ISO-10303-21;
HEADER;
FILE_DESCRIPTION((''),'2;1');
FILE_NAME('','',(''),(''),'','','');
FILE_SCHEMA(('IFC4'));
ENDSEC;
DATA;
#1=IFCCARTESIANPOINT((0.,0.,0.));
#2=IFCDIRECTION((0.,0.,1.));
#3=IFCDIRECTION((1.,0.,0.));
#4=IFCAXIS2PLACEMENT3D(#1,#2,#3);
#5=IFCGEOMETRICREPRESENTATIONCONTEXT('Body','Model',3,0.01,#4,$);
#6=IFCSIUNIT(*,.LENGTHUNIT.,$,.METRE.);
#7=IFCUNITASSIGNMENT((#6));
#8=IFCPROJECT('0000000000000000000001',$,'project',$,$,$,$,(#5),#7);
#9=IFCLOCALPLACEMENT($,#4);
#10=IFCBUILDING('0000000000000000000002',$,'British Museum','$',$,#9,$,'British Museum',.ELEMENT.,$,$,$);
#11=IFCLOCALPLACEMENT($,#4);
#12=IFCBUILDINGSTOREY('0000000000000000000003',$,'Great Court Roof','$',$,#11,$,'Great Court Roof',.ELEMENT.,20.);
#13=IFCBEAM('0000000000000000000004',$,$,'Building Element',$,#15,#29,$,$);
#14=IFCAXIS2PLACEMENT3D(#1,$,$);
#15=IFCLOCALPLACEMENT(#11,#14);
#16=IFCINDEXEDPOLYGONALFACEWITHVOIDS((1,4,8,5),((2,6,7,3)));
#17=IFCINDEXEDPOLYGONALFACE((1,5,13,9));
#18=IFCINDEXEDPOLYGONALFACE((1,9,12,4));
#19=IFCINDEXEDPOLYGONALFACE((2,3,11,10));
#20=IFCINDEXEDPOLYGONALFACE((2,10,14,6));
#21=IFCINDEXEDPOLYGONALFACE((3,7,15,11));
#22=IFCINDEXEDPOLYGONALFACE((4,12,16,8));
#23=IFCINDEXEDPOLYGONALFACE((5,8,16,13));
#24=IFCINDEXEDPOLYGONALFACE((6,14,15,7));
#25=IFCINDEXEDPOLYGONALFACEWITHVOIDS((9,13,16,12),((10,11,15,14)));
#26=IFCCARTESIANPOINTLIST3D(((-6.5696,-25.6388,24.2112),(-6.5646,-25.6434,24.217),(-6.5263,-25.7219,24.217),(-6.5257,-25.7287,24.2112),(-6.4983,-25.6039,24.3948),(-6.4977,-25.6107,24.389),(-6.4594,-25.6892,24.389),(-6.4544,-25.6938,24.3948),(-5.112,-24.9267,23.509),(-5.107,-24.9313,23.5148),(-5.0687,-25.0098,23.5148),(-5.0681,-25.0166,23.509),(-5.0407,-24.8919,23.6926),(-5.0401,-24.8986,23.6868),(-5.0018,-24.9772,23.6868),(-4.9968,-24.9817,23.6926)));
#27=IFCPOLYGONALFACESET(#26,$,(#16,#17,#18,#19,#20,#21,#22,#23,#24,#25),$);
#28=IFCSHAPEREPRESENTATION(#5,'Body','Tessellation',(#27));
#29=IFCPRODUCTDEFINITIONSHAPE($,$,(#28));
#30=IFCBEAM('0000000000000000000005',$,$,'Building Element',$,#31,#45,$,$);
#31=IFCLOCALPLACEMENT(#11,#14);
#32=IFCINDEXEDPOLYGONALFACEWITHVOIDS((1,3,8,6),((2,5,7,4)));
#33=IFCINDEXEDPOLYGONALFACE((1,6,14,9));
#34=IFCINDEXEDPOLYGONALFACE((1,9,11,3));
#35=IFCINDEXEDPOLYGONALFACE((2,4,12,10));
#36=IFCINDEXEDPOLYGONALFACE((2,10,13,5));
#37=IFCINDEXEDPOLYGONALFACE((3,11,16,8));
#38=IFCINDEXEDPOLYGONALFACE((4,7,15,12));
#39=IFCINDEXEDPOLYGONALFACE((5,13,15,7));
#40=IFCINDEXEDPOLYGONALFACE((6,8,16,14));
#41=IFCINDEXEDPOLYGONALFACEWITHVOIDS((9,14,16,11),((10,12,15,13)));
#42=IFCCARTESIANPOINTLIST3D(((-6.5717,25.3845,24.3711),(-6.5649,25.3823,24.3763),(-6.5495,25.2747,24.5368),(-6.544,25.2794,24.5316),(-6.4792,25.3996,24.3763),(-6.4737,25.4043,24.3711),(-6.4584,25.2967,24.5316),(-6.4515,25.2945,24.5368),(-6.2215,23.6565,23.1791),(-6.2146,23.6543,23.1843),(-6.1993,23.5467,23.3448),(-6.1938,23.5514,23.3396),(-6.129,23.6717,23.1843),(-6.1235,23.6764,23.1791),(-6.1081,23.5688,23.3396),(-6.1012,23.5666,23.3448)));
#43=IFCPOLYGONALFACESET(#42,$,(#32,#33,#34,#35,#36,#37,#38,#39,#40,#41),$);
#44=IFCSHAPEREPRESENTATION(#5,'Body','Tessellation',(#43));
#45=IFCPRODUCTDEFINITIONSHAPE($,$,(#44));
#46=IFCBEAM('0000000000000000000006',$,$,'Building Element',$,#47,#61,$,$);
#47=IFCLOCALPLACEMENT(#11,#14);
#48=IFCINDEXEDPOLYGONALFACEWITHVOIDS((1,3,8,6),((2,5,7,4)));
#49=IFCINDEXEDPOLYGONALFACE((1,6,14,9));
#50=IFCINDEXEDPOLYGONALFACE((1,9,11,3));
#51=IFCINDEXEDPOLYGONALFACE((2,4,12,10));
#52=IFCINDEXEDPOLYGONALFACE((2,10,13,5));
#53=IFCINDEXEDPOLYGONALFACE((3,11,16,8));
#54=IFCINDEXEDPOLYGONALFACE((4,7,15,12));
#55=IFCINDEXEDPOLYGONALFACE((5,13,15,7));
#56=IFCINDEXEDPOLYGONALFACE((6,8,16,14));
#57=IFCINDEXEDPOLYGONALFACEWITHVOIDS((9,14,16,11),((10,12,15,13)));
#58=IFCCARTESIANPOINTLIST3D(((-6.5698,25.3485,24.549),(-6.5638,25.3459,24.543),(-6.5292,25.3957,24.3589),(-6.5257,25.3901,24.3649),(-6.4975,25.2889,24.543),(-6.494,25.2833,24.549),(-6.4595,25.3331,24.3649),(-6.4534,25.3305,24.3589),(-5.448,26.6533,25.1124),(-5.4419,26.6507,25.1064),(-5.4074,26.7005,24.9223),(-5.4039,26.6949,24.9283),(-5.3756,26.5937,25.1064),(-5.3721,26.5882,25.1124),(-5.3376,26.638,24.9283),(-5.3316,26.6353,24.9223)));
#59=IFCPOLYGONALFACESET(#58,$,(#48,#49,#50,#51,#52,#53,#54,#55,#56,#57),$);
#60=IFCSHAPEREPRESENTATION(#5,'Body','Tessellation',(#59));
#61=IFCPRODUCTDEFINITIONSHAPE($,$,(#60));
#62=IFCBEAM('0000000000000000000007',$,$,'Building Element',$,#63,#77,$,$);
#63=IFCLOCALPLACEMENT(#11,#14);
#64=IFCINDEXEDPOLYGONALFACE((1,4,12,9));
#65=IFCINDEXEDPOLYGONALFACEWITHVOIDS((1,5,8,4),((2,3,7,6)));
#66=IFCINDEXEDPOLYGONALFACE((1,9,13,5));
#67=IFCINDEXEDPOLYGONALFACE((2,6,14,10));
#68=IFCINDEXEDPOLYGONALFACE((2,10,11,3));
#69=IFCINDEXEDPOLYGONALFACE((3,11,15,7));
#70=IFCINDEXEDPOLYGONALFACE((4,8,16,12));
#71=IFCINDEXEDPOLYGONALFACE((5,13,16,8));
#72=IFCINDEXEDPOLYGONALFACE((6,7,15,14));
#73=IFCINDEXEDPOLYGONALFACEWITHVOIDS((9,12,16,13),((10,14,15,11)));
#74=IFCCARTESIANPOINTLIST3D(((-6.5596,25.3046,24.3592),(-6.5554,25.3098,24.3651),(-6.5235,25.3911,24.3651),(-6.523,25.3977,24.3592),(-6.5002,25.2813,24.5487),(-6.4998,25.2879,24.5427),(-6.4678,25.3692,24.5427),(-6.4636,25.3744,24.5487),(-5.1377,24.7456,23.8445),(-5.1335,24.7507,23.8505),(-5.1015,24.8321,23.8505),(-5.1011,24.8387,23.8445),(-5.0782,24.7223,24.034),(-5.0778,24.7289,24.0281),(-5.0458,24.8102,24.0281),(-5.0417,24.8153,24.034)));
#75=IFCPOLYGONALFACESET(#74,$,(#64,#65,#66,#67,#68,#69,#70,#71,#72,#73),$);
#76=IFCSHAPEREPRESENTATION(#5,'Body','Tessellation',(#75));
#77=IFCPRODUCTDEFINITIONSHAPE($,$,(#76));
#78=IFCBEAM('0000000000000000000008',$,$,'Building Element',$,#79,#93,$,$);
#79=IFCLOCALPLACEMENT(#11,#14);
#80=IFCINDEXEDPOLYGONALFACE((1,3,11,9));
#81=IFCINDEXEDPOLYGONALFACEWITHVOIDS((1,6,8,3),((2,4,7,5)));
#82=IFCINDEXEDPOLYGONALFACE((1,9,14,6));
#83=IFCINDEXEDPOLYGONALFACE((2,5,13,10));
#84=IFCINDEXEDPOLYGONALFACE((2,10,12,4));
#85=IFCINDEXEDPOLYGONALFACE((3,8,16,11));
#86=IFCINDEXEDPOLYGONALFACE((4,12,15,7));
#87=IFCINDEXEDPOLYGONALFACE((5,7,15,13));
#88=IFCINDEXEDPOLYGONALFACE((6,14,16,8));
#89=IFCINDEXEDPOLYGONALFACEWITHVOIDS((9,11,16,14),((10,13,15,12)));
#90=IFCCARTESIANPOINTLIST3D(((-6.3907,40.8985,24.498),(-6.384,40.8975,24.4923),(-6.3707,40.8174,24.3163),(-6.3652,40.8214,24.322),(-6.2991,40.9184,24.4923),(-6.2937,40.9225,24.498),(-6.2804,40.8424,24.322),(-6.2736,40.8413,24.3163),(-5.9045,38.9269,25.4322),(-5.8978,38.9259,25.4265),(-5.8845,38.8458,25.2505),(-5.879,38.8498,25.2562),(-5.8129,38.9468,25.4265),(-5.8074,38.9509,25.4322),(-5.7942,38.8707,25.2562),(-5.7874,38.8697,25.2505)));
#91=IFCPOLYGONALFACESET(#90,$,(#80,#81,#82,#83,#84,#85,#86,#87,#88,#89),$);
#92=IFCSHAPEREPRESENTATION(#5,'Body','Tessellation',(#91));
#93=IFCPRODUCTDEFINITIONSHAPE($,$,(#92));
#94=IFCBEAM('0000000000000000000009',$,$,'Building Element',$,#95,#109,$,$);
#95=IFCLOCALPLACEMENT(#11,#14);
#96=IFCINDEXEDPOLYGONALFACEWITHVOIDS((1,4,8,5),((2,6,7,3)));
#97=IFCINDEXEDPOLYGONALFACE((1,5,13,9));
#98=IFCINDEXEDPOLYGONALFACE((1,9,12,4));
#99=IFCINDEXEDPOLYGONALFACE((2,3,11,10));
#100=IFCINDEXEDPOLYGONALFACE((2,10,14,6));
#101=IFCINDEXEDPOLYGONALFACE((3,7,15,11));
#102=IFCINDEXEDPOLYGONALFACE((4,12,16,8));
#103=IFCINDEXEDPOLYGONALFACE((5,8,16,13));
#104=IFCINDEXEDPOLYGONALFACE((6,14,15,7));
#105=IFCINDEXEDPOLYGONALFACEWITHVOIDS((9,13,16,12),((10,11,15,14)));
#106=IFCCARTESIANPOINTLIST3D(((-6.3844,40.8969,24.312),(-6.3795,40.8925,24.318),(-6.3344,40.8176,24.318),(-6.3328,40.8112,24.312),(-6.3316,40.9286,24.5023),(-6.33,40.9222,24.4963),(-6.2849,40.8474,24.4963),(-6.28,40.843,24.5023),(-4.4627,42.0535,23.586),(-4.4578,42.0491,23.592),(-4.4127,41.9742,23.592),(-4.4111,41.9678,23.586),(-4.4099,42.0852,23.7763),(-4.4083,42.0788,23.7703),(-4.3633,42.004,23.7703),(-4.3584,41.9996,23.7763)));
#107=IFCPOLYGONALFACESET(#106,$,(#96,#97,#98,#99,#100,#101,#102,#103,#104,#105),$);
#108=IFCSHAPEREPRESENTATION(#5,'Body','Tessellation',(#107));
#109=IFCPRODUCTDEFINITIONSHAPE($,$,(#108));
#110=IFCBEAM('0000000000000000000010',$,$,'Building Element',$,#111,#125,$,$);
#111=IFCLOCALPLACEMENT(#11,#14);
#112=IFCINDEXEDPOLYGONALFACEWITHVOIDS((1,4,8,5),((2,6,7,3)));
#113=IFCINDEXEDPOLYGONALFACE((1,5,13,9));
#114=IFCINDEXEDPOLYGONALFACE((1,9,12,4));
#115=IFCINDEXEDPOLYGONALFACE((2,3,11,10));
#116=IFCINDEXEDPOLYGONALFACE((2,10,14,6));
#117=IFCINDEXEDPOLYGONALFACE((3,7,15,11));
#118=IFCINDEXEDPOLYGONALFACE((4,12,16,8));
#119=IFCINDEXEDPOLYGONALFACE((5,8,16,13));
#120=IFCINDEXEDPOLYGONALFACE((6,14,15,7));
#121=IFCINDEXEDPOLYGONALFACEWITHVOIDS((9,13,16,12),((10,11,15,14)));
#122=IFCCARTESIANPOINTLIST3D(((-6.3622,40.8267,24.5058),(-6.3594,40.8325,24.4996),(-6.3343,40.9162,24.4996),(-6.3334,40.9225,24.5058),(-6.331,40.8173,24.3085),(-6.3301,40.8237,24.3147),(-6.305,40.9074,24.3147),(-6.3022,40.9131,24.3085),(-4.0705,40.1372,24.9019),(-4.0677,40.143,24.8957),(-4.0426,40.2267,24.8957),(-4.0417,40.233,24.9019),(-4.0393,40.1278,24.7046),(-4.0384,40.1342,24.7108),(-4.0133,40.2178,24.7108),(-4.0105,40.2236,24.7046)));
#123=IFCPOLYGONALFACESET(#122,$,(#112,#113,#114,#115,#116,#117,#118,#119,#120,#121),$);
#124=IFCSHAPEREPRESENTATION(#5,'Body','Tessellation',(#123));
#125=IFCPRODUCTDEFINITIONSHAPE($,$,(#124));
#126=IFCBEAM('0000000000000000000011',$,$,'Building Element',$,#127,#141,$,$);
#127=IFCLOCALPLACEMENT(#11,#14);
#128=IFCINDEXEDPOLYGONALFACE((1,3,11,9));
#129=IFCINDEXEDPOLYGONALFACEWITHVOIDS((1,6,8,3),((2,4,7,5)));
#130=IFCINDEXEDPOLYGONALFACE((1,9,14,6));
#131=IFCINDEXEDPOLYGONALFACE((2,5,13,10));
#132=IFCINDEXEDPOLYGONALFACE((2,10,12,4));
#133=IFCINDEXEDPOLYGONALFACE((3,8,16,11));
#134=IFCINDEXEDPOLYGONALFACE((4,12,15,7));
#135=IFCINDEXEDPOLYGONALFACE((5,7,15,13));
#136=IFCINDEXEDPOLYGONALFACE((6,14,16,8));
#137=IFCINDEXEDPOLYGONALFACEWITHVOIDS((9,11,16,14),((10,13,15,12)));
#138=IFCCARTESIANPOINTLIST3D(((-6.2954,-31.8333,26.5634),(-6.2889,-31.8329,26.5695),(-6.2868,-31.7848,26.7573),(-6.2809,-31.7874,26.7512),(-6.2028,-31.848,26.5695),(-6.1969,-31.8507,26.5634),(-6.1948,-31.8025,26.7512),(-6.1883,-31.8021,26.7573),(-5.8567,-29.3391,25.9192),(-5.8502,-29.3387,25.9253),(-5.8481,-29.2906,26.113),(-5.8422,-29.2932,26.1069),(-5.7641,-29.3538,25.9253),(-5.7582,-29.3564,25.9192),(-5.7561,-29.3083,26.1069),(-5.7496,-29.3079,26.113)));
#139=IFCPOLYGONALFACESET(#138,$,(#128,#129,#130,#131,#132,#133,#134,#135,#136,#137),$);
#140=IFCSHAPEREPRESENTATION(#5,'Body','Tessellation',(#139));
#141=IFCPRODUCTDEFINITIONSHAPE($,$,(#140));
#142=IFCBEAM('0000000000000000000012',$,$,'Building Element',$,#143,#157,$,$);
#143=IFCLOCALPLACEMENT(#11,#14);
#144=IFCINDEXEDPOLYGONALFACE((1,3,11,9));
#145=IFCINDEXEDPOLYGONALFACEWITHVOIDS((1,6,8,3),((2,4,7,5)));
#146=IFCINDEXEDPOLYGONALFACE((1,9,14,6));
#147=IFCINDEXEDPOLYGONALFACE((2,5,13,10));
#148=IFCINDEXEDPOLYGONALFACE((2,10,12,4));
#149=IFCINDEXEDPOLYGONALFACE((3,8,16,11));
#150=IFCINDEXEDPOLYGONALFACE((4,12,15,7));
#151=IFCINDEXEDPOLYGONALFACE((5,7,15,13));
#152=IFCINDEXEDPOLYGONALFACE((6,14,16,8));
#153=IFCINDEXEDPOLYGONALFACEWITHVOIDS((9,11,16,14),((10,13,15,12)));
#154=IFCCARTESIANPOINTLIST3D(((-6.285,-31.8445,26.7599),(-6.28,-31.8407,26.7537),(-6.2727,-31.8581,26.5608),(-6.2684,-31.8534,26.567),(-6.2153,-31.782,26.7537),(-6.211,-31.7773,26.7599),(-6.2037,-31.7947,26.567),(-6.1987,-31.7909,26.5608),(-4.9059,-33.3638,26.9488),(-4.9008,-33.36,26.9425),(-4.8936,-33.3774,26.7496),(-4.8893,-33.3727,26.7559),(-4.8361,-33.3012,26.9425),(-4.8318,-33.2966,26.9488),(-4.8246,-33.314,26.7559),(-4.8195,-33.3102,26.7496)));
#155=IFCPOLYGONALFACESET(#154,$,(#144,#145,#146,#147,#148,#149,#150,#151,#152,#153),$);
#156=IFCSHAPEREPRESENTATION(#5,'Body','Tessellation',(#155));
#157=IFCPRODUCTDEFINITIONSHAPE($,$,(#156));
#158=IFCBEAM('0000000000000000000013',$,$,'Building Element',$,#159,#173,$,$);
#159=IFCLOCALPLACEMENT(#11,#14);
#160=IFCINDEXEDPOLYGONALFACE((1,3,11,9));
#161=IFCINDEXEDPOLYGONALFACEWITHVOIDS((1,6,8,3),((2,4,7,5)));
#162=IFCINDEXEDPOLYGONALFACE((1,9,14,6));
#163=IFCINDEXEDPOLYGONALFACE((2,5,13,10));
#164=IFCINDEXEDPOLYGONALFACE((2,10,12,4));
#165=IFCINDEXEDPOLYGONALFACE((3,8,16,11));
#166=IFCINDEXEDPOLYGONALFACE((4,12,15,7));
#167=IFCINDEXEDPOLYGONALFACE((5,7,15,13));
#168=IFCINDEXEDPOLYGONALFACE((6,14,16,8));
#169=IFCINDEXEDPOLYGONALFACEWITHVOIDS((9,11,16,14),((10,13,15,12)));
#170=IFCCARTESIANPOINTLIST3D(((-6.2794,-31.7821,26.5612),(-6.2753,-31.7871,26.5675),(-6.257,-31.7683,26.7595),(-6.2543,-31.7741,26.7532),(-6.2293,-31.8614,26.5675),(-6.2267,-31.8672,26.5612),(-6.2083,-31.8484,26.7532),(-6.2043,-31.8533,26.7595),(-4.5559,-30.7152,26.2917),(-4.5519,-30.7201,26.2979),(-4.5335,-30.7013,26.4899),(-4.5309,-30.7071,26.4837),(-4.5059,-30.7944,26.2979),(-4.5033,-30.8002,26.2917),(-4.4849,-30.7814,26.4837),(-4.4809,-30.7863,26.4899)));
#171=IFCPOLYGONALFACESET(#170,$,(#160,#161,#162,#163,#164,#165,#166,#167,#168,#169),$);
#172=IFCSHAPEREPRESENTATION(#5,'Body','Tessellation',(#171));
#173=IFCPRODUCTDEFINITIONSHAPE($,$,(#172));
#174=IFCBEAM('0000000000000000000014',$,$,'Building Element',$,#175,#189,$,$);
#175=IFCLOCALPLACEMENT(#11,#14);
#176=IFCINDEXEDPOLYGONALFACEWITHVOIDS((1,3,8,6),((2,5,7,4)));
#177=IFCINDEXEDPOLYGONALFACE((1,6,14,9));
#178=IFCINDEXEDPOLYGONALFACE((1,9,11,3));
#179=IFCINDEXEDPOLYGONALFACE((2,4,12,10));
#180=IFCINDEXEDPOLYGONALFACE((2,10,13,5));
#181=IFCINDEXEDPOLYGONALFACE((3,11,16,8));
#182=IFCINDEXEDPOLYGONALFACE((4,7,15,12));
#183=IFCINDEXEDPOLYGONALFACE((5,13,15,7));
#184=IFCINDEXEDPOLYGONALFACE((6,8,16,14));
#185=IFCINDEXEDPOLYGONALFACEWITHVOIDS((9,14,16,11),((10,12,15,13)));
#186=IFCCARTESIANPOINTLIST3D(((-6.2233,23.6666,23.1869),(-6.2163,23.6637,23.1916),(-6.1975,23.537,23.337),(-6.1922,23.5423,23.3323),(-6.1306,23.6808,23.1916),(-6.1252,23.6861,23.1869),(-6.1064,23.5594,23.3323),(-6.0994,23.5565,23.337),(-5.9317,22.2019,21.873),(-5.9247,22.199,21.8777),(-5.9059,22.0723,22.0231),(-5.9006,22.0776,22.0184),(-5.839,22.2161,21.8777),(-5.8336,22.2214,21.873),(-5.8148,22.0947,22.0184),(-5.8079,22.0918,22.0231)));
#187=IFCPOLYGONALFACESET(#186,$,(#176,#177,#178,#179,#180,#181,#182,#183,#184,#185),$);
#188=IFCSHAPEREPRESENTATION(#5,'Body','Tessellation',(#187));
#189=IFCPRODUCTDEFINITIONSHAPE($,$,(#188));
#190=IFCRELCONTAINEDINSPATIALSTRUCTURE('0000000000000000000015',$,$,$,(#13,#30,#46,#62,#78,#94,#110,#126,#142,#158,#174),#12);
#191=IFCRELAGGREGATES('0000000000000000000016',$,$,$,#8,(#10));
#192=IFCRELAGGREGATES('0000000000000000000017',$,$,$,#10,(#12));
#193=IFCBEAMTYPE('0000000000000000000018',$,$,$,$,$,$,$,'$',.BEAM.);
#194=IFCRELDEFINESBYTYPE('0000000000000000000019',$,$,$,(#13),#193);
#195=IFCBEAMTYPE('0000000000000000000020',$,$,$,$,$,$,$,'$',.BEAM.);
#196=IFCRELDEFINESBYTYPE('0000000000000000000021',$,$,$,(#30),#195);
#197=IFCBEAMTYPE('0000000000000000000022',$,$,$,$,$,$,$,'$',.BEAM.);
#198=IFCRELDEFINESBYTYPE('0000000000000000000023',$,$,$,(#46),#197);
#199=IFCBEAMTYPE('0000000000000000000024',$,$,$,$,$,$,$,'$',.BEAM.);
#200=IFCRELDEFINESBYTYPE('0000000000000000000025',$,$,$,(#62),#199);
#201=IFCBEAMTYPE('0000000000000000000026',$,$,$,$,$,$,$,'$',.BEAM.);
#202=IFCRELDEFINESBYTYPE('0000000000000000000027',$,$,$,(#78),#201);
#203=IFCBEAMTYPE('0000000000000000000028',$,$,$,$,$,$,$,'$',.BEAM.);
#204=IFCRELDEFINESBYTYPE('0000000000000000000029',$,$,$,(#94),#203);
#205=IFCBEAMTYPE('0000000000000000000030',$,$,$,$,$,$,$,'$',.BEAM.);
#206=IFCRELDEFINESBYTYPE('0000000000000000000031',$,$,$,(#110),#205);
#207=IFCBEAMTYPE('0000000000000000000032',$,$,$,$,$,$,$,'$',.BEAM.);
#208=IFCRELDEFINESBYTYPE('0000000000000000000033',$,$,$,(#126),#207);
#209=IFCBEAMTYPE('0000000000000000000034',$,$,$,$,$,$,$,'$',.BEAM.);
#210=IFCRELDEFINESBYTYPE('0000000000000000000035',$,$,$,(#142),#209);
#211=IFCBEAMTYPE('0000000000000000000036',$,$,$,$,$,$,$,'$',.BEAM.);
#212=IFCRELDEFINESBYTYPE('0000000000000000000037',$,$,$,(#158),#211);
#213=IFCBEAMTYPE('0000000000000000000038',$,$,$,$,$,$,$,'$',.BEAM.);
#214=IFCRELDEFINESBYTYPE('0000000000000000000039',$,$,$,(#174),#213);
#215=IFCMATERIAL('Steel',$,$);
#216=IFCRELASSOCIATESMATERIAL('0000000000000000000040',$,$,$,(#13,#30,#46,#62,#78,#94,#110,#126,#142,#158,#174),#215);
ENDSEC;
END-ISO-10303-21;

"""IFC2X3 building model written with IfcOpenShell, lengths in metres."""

from ifc_helpers import new_model, si_unit, frame, origin_with_axes, origin_2d, place, context, project, spatial, hollow_rectangle, extrude, material, type_object, element, save


model = new_model("IFC2X3")

# Units and contexts
model_context = context("Model", 3, precision=0.01, world=origin_with_axes(), identifier="Body")
ifc_project = project(units=[si_unit("LENGTHUNIT", "METRE")], contexts=[model_context])

# Building, storey
building_placement = place(None, origin_with_axes())
building = spatial("IfcBuilding", under=ifc_project, at=building_placement, Name="British Museum", Description="$", LongName="British Museum", CompositionType="ELEMENT")
storey_placement = place(None, origin_with_axes())
storey = spatial("IfcBuildingStorey", under=building, at=storey_placement, Name="Great Court Roof", Description="$", LongName="Great Court Roof", CompositionType="ELEMENT", Elevation=20.0)

# Beams
ifc_material = material(Name="Steel")
beam_type_1 = type_object("IfcBeamType", ElementType="$", PredefinedType="BEAM")
beam_1_placement = place(None, origin_with_axes())
element("IfcBeam", 1, at=beam_1_placement, inside=storey, type_object=beam_type_1, material=ifc_material, Description="Building Element", context=model_context, shape_type="SweptSolid", body=[
    extrude(hollow_rectangle(XDim=0.1, YDim=0.2, WallThickness=0.0063, InnerFilletRadius=-0.0063, OuterFilletRadius=0.0, at=origin_2d()), frame((-6.512, -25.6663, 24.303), z_axis=(0.824581, 0.40283, -0.397234), x_axis=(-0.438948, 0.898513, 0.0)), (0.0, 0.0, 1.0), 1.7677),
])
beam_type_2 = type_object("IfcBeamType", ElementType="$", PredefinedType="BEAM")
beam_2_placement = place(None, origin_with_axes())
element("IfcBeam", 2, at=beam_2_placement, inside=storey, type_object=beam_type_2, material=ifc_material, Description="Building Element", context=model_context, shape_type="SweptSolid", body=[
    extrude(hollow_rectangle(XDim=0.1, YDim=0.2, WallThickness=0.0063, InnerFilletRadius=-0.0063, OuterFilletRadius=0.0, at=origin_2d()), frame((-6.5116, 25.3395, 24.4539), z_axis=(0.164564, -0.811926, -0.560085), x_axis=(0.980072, 0.198644, 0.0)), (0.0, 0.0, 1.0), 2.1282),
])
beam_type_3 = type_object("IfcBeamType", ElementType="$", PredefinedType="BEAM")
beam_3_placement = place(None, origin_with_axes())
element("IfcBeam", 3, at=beam_3_placement, inside=storey, type_object=beam_type_3, material=ifc_material, Description="Building Element", context=model_context, shape_type="SweptSolid", body=[
    extrude(hollow_rectangle(XDim=0.1, YDim=0.2, WallThickness=0.0063, InnerFilletRadius=-0.0063, OuterFilletRadius=0.0, at=origin_2d()), frame((-6.5116, 25.3395, 24.4539), z_axis=(0.61956, 0.720638, 0.311169), x_axis=(-0.758283, 0.651925, 0.0)), (0.0, 0.0, 1.0), 1.8107),
])
beam_type_4 = type_object("IfcBeamType", ElementType="$", PredefinedType="BEAM")
beam_4_placement = place(None, origin_with_axes())
element("IfcBeam", 4, at=beam_4_placement, inside=storey, type_object=beam_type_4, material=ifc_material, Description="Building Element", context=model_context, shape_type="SweptSolid", body=[
    extrude(hollow_rectangle(XDim=0.1, YDim=0.2, WallThickness=0.0063, InnerFilletRadius=-0.0063, OuterFilletRadius=0.0, at=origin_2d()), frame((-6.5116, 25.3395, 24.4539), z_axis=(0.881967, -0.34674, -0.319227), x_axis=(0.365884, 0.930661, 0.0)), (0.0, 0.0, 1.0), 1.6122),
])
beam_type_5 = type_object("IfcBeamType", ElementType="$", PredefinedType="BEAM")
beam_5_placement = place(None, origin_with_axes())
element("IfcBeam", 5, at=beam_5_placement, inside=storey, type_object=beam_type_5, material=ifc_material, Description="Building Element", context=model_context, shape_type="SweptSolid", body=[
    extrude(hollow_rectangle(XDim=0.1, YDim=0.2, WallThickness=0.0063, InnerFilletRadius=-0.0063, OuterFilletRadius=0.0, at=origin_2d()), frame((-6.3322, 40.8699, 24.4071), z_axis=(0.21753, -0.882046, 0.417942), x_axis=(0.97091, 0.239446, 0.0)), (0.0, 0.0, 1.0), 2.2353),
])
beam_type_6 = type_object("IfcBeamType", ElementType="$", PredefinedType="BEAM")
beam_6_placement = place(None, origin_with_axes())
element("IfcBeam", 6, at=beam_6_placement, inside=storey, type_object=beam_type_6, material=ifc_material, Description="Building Element", context=model_context, shape_type="SweptSolid", body=[
    extrude(hollow_rectangle(XDim=0.1, YDim=0.2, WallThickness=0.0063, InnerFilletRadius=-0.0063, OuterFilletRadius=0.0, at=origin_2d()), frame((-6.3322, 40.8699, 24.4071), z_axis=(0.815139, 0.490617, -0.307967), x_axis=(-0.515681, 0.856781, 0.0)), (0.0, 0.0, 1.0), 2.3575),
])
beam_type_7 = type_object("IfcBeamType", ElementType="$", PredefinedType="BEAM")
beam_7_placement = place(None, origin_with_axes())
element("IfcBeam", 7, at=beam_7_placement, inside=storey, type_object=beam_type_7, material=ifc_material, Description="Building Element", context=model_context, shape_type="SweptSolid", body=[
    extrude(hollow_rectangle(XDim=0.1, YDim=0.2, WallThickness=0.0063, InnerFilletRadius=-0.0063, OuterFilletRadius=0.0, at=origin_2d()), frame((-6.3322, 40.8699, 24.4071), z_axis=(0.944741, -0.284246, 0.163304), x_axis=(0.288113, 0.957596, 0.0)), (0.0, 0.0, 1.0), 2.4257),
])
beam_type_8 = type_object("IfcBeamType", ElementType="$", PredefinedType="BEAM")
beam_8_placement = place(None, origin_with_axes())
element("IfcBeam", 8, at=beam_8_placement, inside=storey, type_object=beam_type_8, material=ifc_material, Description="Building Element", context=model_context, shape_type="SweptSolid", body=[
    extrude(hollow_rectangle(XDim=0.1, YDim=0.2, WallThickness=0.0063, InnerFilletRadius=-0.0063, OuterFilletRadius=0.0, at=origin_2d()), frame((-6.2418, -31.8177, 26.6603), z_axis=(0.167882, 0.954478, -0.246549), x_axis=(-0.984881, 0.17323, 0.0)), (0.0, 0.0, 1.0), 2.6132),
])
beam_type_9 = type_object("IfcBeamType", ElementType="$", PredefinedType="BEAM")
beam_9_placement = place(None, origin_with_axes())
element("IfcBeam", 9, at=beam_9_placement, inside=storey, type_object=beam_type_9, material=ifc_material, Description="Building Element", context=model_context, shape_type="SweptSolid", body=[
    extrude(hollow_rectangle(XDim=0.1, YDim=0.2, WallThickness=0.0063, InnerFilletRadius=-0.0063, OuterFilletRadius=0.0, at=origin_2d()), frame((-6.2418, -31.8177, 26.6603), z_axis=(0.669309, -0.73731, 0.091645), x_axis=(0.740426, 0.672137, 0.0)), (0.0, 0.0, 1.0), 2.0605),
])
beam_type_10 = type_object("IfcBeamType", ElementType="$", PredefinedType="BEAM")
beam_10_placement = place(None, origin_with_axes())
element("IfcBeam", 10, at=beam_10_placement, inside=storey, type_object=beam_type_10, material=ifc_material, Description="Building Element", context=model_context, shape_type="SweptSolid", body=[
    extrude(hollow_rectangle(XDim=0.1, YDim=0.2, WallThickness=0.0063, InnerFilletRadius=-0.0063, OuterFilletRadius=0.0, at=origin_2d()), frame((-6.2418, -31.8177, 26.6603), z_axis=(0.842831, 0.521787, -0.131813), x_axis=(-0.526379, 0.85025, 0.0)), (0.0, 0.0, 1.0), 2.0448),
])
beam_type_11 = type_object("IfcBeamType", ElementType="$", PredefinedType="BEAM")
beam_11_placement = place(None, origin_with_axes())
element("IfcBeam", 11, at=beam_11_placement, inside=storey, type_object=beam_type_11, material=ifc_material, Description="Building Element", context=model_context, shape_type="SweptSolid", body=[
    extrude(hollow_rectangle(XDim=0.1, YDim=0.2, WallThickness=0.0063, InnerFilletRadius=-0.0063, OuterFilletRadius=0.0, at=origin_2d()), frame((-6.1614, 23.6115, 23.262), z_axis=(0.146588, -0.736343, -0.660539), x_axis=(0.980755, 0.195244, 0.0)), (0.0, 0.0, 1.0), 1.9892),
])

save(model, "model.ifc")
